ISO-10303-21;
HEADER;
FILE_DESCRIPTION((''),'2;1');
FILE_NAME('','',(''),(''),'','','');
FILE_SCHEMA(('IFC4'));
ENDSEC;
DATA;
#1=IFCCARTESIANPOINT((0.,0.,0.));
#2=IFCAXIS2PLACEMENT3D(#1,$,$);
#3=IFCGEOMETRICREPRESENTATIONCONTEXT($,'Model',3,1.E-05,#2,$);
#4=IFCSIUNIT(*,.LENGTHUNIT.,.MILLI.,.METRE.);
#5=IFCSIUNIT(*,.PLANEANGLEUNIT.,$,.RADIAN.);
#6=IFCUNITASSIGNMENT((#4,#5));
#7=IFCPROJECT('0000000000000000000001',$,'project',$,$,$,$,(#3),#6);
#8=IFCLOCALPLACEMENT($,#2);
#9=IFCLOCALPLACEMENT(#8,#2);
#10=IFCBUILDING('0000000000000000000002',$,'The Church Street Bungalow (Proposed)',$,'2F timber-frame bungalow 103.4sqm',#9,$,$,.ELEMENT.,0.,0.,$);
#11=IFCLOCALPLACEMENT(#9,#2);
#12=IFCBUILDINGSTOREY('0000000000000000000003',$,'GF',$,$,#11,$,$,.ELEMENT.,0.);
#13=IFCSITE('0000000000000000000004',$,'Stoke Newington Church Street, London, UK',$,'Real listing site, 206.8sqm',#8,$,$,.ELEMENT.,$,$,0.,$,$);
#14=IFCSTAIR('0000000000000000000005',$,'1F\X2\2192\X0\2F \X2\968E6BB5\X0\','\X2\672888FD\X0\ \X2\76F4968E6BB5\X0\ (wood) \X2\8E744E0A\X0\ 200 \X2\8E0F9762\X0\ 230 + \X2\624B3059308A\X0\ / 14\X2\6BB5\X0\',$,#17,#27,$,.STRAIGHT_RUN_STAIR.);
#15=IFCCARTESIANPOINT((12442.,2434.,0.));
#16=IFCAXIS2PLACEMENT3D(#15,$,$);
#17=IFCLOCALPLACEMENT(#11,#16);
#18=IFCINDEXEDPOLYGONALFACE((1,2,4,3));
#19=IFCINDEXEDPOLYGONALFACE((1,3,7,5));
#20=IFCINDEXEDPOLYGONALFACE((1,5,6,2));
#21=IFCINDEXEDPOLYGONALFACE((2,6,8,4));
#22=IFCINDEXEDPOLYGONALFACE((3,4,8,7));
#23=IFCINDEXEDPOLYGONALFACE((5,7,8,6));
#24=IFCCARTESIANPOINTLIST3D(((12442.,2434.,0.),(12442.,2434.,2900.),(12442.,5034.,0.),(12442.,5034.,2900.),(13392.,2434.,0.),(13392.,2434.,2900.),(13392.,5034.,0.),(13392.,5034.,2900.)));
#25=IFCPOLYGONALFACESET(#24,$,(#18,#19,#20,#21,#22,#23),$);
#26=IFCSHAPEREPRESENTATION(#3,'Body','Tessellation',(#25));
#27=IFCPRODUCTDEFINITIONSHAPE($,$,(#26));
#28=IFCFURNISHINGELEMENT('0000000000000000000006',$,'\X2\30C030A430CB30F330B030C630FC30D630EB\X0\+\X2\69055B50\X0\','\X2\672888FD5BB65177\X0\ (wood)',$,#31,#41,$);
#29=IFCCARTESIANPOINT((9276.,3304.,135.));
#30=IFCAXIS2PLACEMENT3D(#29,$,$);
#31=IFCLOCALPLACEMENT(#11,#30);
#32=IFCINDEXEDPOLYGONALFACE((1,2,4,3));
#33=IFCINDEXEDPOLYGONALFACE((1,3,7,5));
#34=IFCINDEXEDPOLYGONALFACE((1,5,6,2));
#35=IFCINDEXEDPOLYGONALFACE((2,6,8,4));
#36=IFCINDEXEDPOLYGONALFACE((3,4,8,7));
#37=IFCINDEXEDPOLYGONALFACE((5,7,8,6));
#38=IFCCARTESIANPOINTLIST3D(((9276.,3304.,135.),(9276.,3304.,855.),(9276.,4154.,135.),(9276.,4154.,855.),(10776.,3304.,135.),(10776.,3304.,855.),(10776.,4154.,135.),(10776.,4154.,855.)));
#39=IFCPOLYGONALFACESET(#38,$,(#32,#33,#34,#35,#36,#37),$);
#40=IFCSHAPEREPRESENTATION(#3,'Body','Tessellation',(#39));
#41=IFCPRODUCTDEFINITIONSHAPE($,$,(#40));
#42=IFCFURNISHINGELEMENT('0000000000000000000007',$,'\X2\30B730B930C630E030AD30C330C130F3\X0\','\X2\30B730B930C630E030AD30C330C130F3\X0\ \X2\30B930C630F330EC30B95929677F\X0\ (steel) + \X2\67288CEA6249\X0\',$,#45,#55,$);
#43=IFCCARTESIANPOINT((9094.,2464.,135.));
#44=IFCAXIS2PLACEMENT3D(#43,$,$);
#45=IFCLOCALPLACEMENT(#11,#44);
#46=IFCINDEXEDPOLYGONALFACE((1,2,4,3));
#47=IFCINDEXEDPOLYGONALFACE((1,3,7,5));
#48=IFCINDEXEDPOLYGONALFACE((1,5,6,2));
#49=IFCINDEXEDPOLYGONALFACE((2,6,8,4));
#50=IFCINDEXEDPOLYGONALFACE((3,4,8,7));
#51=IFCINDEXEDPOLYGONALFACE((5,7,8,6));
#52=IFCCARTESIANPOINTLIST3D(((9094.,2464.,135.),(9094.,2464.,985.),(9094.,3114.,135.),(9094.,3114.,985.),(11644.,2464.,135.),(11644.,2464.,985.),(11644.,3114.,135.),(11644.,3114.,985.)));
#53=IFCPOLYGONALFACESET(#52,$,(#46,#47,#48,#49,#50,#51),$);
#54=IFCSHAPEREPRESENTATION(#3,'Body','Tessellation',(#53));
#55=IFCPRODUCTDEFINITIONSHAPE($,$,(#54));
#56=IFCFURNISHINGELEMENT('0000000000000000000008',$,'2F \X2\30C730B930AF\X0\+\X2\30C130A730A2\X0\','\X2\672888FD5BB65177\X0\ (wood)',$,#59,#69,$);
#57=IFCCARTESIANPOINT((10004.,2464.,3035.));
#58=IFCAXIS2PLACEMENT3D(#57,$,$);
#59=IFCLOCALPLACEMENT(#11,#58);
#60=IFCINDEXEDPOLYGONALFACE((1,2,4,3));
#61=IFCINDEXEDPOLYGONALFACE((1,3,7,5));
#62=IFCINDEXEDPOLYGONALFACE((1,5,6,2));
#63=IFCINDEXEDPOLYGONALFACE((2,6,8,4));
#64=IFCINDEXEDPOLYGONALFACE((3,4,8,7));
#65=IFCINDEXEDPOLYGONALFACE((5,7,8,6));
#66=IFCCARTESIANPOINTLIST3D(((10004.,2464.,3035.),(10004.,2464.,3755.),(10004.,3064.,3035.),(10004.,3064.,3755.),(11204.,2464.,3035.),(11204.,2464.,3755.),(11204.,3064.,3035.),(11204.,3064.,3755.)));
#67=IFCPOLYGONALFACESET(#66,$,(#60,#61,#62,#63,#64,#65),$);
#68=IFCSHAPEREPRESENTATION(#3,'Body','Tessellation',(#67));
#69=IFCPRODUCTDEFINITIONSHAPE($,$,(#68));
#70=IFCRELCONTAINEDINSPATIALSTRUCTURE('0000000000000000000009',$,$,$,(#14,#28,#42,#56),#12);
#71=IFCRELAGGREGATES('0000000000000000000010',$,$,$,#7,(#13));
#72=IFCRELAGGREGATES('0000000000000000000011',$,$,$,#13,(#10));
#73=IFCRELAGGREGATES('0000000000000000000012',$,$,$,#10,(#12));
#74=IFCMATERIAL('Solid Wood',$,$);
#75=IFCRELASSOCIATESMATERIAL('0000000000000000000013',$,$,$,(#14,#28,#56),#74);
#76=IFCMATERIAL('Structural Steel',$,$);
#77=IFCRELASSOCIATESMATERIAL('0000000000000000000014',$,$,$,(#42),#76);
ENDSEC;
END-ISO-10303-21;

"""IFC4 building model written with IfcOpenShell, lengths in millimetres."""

from ifc_helpers import new_model, si_unit, frame, frame_2d, origin, place, context, project, spatial, rectangle, extrude, material, element, save


model = new_model("IFC4")

# Units and contexts
model_context = context("Model", 3, precision=1e-05, world=origin())
ifc_project = project(units=[si_unit("LENGTHUNIT", "METRE", prefix="MILLI"), si_unit("PLANEANGLEUNIT", "RADIAN")], contexts=[model_context])

# Site, building, storey
site_placement = place(None, origin())
site = spatial("IfcSite", under=ifc_project, at=site_placement, Name="Stoke Newington Church Street, London, UK", ObjectType="Real listing site, 206.8sqm", CompositionType="ELEMENT", RefElevation=0.0)
building_placement = place(site_placement, origin())
building = spatial("IfcBuilding", under=site, at=building_placement, Name="The Church Street Bungalow (Proposed)", ObjectType="2F timber-frame bungalow 103.4sqm", CompositionType="ELEMENT", ElevationOfRefHeight=0.0, ElevationOfTerrain=0.0)
storey_placement = place(building_placement, origin())
storey = spatial("IfcBuildingStorey", under=building, at=storey_placement, Name="GF", CompositionType="ELEMENT", Elevation=0.0)

# Shared definitions
ifc_material_1 = material(Name="Solid Wood")

# Stair
stair_placement = place(storey_placement, frame((12442.0, 2434.0, 0.0)))
element("IfcStair", 1, at=stair_placement, inside=storey, material=ifc_material_1, Name="1F→2F 階段", Description="木製 直階段 (wood) 蹴上 200 踏面 230 + 手すり / 14段", PredefinedType="STRAIGHT_RUN_STAIR", context=model_context, shape_type="SweptSolid", body=[
    extrude(rectangle(XDim=950.0, YDim=2600.0, at=frame_2d((475.0, 1300.0))), frame((12442.0, 2434.0, 0.0)), (0.0, 0.0, 1.0), 2900.0),
])

# Furnishing elements
furnishing_1_placement = place(storey_placement, frame((9276.0, 3304.0, 135.0)))
element("IfcFurnishingElement", 2, at=furnishing_1_placement, inside=storey, material=ifc_material_1, Name="ダイニングテーブル+椅子", Description="木製家具 (wood)", context=model_context, shape_type="SweptSolid", body=[
    extrude(rectangle(XDim=1500.0, YDim=850.0, at=frame_2d((750.0, 425.0))), frame((9276.0, 3304.0, 135.0)), (0.0, 0.0, 1.0), 720.0),
])
ifc_material_2 = material(Name="Structural Steel")
furnishing_2_placement = place(storey_placement, frame((9094.0, 2464.0, 135.0)))
element("IfcFurnishingElement", 3, at=furnishing_2_placement, inside=storey, material=ifc_material_2, Name="システムキッチン", Description="システムキッチン ステンレス天板 (steel) + 木質扉", context=model_context, shape_type="SweptSolid", body=[
    extrude(rectangle(XDim=2550.0, YDim=650.0, at=frame_2d((1275.0, 325.0))), frame((9094.0, 2464.0, 135.0)), (0.0, 0.0, 1.0), 850.0),
])
furnishing_3_placement = place(storey_placement, frame((10004.0, 2464.0, 3035.0)))
element("IfcFurnishingElement", 4, at=furnishing_3_placement, inside=storey, material=ifc_material_1, Name="2F デスク+チェア", Description="木製家具 (wood)", context=model_context, shape_type="SweptSolid", body=[
    extrude(rectangle(XDim=1200.0, YDim=600.0, at=frame_2d((600.0, 300.0))), frame((10004.0, 2464.0, 3035.0)), (0.0, 0.0, 1.0), 720.0),
])

save(model, "model.ifc")
